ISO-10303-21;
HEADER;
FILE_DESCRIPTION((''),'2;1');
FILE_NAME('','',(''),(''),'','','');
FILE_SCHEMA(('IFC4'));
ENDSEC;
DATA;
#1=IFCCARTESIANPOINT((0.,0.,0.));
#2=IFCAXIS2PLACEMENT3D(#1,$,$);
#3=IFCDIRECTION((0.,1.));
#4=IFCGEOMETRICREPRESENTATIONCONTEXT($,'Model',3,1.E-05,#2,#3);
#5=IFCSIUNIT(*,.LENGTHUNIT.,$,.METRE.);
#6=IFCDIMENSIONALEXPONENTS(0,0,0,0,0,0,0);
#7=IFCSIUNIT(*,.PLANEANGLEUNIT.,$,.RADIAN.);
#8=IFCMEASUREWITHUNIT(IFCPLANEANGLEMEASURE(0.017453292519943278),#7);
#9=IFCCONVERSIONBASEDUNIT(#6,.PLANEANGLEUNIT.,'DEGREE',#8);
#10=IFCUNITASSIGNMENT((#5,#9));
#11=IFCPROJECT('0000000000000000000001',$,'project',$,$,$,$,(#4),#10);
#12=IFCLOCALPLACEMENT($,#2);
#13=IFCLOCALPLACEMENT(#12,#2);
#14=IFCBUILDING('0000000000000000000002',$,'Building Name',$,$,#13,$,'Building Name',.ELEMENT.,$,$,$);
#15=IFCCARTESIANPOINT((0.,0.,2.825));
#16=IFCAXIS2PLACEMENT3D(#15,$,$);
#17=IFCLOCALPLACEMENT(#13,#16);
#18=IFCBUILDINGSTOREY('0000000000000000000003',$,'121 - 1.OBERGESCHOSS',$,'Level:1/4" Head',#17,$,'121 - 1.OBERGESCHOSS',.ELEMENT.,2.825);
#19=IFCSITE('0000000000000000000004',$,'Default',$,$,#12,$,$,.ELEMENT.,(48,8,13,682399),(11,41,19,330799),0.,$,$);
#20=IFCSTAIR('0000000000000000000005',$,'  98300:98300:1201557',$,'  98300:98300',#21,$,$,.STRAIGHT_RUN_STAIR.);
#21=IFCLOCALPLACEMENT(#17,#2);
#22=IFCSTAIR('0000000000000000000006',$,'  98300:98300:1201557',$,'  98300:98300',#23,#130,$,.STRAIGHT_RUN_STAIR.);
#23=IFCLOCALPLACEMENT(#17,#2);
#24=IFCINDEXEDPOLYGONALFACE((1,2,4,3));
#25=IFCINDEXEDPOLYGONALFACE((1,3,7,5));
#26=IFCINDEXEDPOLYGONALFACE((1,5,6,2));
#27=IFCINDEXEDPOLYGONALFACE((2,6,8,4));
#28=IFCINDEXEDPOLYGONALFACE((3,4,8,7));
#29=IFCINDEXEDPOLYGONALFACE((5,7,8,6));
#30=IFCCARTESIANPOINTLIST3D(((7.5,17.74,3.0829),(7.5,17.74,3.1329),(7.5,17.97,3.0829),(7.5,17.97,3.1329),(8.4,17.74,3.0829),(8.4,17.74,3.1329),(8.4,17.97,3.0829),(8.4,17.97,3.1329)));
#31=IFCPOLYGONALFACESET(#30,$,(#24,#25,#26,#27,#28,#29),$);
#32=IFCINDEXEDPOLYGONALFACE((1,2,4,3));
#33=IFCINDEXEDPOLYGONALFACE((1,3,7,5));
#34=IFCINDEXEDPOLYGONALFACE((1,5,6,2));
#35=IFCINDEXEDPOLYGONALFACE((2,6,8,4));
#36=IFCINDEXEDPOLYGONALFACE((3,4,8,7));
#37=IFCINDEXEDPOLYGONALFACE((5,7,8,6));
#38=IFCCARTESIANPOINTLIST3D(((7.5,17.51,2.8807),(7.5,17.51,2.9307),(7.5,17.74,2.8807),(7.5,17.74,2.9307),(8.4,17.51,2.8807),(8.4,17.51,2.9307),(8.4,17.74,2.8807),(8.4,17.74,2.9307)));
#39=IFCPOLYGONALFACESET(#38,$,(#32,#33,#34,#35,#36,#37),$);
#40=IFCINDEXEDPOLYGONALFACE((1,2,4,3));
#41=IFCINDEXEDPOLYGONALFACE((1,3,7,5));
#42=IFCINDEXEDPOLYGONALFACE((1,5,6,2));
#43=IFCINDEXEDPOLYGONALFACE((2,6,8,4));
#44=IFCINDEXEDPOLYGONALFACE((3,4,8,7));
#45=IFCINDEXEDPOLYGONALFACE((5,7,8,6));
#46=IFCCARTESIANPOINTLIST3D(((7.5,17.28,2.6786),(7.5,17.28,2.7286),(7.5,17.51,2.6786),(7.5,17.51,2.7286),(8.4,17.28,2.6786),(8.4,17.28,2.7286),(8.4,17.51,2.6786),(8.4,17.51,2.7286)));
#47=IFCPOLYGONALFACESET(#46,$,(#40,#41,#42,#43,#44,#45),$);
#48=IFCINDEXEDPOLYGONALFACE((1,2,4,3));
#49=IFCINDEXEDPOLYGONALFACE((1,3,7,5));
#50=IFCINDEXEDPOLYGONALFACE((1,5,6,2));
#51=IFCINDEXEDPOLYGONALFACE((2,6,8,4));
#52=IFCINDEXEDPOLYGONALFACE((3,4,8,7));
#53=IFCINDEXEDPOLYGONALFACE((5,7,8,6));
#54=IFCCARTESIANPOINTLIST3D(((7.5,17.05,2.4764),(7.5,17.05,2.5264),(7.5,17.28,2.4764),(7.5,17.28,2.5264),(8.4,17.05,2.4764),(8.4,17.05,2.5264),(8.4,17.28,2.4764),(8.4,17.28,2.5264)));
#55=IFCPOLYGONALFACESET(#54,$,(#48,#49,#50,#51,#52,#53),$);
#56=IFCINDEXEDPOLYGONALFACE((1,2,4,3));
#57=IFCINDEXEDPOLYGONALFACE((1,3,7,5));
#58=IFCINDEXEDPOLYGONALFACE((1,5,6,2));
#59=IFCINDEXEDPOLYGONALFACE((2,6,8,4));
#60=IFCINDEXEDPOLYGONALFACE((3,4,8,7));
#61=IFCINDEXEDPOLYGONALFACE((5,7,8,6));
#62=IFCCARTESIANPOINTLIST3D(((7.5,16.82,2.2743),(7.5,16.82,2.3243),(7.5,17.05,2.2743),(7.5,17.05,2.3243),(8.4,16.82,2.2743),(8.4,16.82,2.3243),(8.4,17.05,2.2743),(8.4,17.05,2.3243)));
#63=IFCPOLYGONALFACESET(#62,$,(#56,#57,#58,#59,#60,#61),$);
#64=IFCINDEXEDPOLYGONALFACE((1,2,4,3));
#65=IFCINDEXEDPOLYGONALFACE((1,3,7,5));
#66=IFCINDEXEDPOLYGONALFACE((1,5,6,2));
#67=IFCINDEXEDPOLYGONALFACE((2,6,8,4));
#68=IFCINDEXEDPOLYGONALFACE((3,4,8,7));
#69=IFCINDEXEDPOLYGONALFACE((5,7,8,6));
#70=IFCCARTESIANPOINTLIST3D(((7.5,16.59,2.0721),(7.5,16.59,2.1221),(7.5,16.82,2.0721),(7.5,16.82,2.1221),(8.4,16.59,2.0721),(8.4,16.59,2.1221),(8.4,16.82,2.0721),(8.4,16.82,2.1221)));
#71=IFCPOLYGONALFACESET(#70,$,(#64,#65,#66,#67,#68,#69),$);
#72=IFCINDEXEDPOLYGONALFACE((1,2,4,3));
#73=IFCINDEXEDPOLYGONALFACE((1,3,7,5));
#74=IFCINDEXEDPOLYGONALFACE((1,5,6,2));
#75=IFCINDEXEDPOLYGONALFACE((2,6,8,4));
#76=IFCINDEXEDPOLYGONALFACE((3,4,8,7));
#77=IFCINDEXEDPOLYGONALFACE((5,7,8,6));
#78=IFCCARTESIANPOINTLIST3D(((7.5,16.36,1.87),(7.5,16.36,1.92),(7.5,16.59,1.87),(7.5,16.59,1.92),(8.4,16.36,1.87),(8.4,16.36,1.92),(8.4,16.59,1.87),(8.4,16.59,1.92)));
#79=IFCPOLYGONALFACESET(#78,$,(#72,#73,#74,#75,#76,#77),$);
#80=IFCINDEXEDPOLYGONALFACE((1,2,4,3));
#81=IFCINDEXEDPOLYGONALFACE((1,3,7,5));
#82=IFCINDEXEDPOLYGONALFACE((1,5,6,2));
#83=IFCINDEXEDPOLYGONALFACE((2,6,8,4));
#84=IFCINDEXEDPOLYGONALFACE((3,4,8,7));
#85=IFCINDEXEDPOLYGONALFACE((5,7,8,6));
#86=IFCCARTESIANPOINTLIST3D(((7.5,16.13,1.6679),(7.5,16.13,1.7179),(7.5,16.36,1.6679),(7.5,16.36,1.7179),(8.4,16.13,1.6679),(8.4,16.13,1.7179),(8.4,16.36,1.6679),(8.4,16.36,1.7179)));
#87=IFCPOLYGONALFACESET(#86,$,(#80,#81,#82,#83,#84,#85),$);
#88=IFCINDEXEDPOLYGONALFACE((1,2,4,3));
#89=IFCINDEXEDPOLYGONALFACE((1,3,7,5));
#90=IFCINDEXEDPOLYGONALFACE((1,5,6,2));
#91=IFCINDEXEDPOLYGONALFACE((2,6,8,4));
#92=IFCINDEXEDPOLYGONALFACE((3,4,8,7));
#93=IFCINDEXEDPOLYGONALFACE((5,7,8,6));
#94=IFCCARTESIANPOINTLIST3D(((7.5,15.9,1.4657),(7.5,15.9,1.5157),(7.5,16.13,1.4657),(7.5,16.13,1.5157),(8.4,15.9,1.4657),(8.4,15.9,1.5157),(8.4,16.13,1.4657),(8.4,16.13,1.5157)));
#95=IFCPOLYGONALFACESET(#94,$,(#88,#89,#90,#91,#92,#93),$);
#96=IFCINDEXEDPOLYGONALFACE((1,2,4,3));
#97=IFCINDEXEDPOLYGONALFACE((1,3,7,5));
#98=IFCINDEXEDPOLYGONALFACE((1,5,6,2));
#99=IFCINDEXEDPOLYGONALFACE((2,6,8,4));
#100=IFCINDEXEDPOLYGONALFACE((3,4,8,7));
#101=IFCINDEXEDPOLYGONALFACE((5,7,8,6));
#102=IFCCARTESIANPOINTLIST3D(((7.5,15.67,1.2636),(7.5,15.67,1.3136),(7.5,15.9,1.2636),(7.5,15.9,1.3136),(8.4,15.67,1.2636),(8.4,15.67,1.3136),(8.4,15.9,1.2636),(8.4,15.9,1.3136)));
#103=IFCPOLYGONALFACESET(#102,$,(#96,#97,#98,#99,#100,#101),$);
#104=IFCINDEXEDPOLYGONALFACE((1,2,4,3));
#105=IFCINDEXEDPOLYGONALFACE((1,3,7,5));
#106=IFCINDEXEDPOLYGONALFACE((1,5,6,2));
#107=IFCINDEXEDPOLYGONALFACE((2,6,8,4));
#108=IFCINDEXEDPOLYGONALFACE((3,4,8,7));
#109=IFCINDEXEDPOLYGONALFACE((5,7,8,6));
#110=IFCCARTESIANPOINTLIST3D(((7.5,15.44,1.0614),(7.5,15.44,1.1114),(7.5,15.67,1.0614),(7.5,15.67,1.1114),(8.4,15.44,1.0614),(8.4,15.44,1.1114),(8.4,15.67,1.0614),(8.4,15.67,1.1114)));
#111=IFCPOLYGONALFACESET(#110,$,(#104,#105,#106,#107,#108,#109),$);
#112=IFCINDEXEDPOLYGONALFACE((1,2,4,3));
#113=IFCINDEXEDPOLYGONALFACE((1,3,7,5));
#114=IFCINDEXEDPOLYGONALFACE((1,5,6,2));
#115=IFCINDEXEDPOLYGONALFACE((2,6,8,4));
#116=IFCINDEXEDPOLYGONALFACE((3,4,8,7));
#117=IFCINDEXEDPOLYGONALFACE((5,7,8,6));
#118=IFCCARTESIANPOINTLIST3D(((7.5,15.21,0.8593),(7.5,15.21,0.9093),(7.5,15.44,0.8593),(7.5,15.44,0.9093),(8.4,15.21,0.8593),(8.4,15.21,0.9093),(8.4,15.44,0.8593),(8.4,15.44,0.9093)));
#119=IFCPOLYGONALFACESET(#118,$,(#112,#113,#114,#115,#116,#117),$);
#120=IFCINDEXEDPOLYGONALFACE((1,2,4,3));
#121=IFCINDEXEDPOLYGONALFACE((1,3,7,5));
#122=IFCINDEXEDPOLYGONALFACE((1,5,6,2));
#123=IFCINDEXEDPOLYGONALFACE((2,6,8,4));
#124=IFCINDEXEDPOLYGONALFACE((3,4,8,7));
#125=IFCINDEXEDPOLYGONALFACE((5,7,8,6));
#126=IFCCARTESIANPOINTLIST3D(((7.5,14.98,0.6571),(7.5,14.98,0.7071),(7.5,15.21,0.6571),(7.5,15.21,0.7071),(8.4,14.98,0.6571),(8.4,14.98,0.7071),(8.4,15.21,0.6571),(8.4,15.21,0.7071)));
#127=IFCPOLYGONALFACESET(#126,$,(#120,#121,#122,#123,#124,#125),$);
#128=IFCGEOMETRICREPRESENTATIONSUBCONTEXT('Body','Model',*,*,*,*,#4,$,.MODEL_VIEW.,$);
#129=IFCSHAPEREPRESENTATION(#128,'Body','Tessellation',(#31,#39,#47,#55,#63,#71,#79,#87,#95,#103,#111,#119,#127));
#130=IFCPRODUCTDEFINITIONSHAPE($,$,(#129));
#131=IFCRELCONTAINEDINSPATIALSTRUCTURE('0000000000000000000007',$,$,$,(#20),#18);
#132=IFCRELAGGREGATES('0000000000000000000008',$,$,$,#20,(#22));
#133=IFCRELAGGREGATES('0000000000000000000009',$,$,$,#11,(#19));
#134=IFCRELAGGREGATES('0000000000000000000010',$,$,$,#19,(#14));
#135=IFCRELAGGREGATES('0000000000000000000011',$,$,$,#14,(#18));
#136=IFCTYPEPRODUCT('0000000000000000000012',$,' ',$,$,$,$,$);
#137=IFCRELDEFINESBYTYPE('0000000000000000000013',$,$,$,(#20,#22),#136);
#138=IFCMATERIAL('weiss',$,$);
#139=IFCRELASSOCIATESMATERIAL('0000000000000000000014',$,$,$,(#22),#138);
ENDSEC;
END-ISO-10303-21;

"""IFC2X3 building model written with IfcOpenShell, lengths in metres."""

from ifc_helpers import new_model, entity, si_unit, converted_unit, direction, frame, origin, origin_2d_with_axis, place, context, subcontext, project, spatial, rectangle, extrude, material, type_object, element, aggregate, save


model = new_model("IFC2X3")

# Units and contexts
model_context = context("Model", 3, precision=1e-05, world=origin(), true_north=direction((0.0, 1.0)))
body_context = subcontext(model_context, "Body", "Model", "MODEL_VIEW")
ifc_project = project(units=[si_unit("LENGTHUNIT", "METRE"), converted_unit("PLANEANGLEUNIT", "DEGREE", entity("IfcPlaneAngleMeasure", 0.017453292519943278), si_unit("PLANEANGLEUNIT", "RADIAN"), dimensions=[0, 0, 0, 0, 0, 0, 0])], contexts=[model_context])

# Site, building, storey
site_placement = place(None, origin())
site = spatial("IfcSite", under=ifc_project, at=site_placement, Name="Default", CompositionType="ELEMENT", RefLatitude=(48, 8, 13, 682399), RefLongitude=(11, 41, 19, 330799), RefElevation=0.0)
building_placement = place(site_placement, origin())
building = spatial("IfcBuilding", under=site, at=building_placement, Name="Building Name", LongName="Building Name", CompositionType="ELEMENT")
storey_placement = place(building_placement, frame((0.0, 0.0, 2.825)))
storey = spatial("IfcBuildingStorey", under=building, at=storey_placement, Name="121 - 1.OBERGESCHOSS", ObjectType="Level:1/4\" Head", LongName="121 - 1.OBERGESCHOSS", CompositionType="ELEMENT", Elevation=2.825)

# Stairs
ifc_material_1 = material(Name="weiss")
type_product_1 = type_object("IfcTypeProduct", Name=" ")
stair_1_placement = place(storey_placement, origin())
stair_1 = element("IfcStair", 1, at=stair_1_placement, inside=storey, type_object=type_product_1, Name="  98300:98300:1201557", ObjectType="  98300:98300", ShapeType="STRAIGHT_RUN_STAIR")
stair_2_placement = place(stair_1_placement, origin())
stair_2 = element("IfcStair", 2, at=stair_2_placement, type_object=type_product_1, material=ifc_material_1, Name="  98300:98300:1201557", ObjectType="  98300:98300", ShapeType="STRAIGHT_RUN_STAIR", context=body_context, shape_type="SweptSolid", body=[
    extrude(rectangle(XDim=0.9, YDim=0.23, at=origin_2d_with_axis()), frame((7.95, 17.855, 3.0829), z_axis=(0.0, 0.0, 1.0), x_axis=(-1.0, 0.0, 0.0)), (0.0, 0.0, 1.0), 0.05),
    extrude(rectangle(XDim=0.9, YDim=0.23, at=origin_2d_with_axis()), frame((7.95, 17.625, 2.8807), z_axis=(0.0, 0.0, 1.0), x_axis=(-1.0, 0.0, 0.0)), (0.0, 0.0, 1.0), 0.05),
    extrude(rectangle(XDim=0.9, YDim=0.23, at=origin_2d_with_axis()), frame((7.95, 17.395, 2.6786), z_axis=(0.0, 0.0, 1.0), x_axis=(-1.0, 0.0, 0.0)), (0.0, 0.0, 1.0), 0.05),
    extrude(rectangle(XDim=0.9, YDim=0.23, at=origin_2d_with_axis()), frame((7.95, 17.165, 2.4764), z_axis=(0.0, 0.0, 1.0), x_axis=(-1.0, 0.0, 0.0)), (0.0, 0.0, 1.0), 0.05),
    extrude(rectangle(XDim=0.9, YDim=0.23, at=origin_2d_with_axis()), frame((7.95, 16.935, 2.2743), z_axis=(0.0, 0.0, 1.0), x_axis=(-1.0, 0.0, 0.0)), (0.0, 0.0, 1.0), 0.05),
    extrude(rectangle(XDim=0.9, YDim=0.23, at=origin_2d_with_axis()), frame((7.95, 16.705, 2.0721), z_axis=(0.0, 0.0, 1.0), x_axis=(-1.0, 0.0, 0.0)), (0.0, 0.0, 1.0), 0.05),
    extrude(rectangle(XDim=0.9, YDim=0.23, at=origin_2d_with_axis()), frame((7.95, 16.475, 1.87), z_axis=(0.0, 0.0, 1.0), x_axis=(-1.0, 0.0, 0.0)), (0.0, 0.0, 1.0), 0.05),
    extrude(rectangle(XDim=0.9, YDim=0.23, at=origin_2d_with_axis()), frame((7.95, 16.245, 1.6679), z_axis=(0.0, 0.0, 1.0), x_axis=(-1.0, 0.0, 0.0)), (0.0, 0.0, 1.0), 0.05),
    extrude(rectangle(XDim=0.9, YDim=0.23, at=origin_2d_with_axis()), frame((7.95, 16.015, 1.4657), z_axis=(0.0, 0.0, 1.0), x_axis=(-1.0, 0.0, 0.0)), (0.0, 0.0, 1.0), 0.05),
    extrude(rectangle(XDim=0.9, YDim=0.23, at=origin_2d_with_axis()), frame((7.95, 15.785, 1.2636), z_axis=(0.0, 0.0, 1.0), x_axis=(-1.0, 0.0, 0.0)), (0.0, 0.0, 1.0), 0.05),
    extrude(rectangle(XDim=0.9, YDim=0.23, at=origin_2d_with_axis()), frame((7.95, 15.555, 1.0614), z_axis=(0.0, 0.0, 1.0), x_axis=(-1.0, 0.0, 0.0)), (0.0, 0.0, 1.0), 0.05),
    extrude(rectangle(XDim=0.9, YDim=0.23, at=origin_2d_with_axis()), frame((7.95, 15.325, 0.8593), z_axis=(0.0, 0.0, 1.0), x_axis=(-1.0, 0.0, 0.0)), (0.0, 0.0, 1.0), 0.05),
    extrude(rectangle(XDim=0.9, YDim=0.23, at=origin_2d_with_axis()), frame((7.95, 15.095, 0.6571), z_axis=(0.0, 0.0, 1.0), x_axis=(-1.0, 0.0, 0.0)), (0.0, 0.0, 1.0), 0.05),
])
aggregate(stair_1, [stair_2])

save(model, "model.ifc")
